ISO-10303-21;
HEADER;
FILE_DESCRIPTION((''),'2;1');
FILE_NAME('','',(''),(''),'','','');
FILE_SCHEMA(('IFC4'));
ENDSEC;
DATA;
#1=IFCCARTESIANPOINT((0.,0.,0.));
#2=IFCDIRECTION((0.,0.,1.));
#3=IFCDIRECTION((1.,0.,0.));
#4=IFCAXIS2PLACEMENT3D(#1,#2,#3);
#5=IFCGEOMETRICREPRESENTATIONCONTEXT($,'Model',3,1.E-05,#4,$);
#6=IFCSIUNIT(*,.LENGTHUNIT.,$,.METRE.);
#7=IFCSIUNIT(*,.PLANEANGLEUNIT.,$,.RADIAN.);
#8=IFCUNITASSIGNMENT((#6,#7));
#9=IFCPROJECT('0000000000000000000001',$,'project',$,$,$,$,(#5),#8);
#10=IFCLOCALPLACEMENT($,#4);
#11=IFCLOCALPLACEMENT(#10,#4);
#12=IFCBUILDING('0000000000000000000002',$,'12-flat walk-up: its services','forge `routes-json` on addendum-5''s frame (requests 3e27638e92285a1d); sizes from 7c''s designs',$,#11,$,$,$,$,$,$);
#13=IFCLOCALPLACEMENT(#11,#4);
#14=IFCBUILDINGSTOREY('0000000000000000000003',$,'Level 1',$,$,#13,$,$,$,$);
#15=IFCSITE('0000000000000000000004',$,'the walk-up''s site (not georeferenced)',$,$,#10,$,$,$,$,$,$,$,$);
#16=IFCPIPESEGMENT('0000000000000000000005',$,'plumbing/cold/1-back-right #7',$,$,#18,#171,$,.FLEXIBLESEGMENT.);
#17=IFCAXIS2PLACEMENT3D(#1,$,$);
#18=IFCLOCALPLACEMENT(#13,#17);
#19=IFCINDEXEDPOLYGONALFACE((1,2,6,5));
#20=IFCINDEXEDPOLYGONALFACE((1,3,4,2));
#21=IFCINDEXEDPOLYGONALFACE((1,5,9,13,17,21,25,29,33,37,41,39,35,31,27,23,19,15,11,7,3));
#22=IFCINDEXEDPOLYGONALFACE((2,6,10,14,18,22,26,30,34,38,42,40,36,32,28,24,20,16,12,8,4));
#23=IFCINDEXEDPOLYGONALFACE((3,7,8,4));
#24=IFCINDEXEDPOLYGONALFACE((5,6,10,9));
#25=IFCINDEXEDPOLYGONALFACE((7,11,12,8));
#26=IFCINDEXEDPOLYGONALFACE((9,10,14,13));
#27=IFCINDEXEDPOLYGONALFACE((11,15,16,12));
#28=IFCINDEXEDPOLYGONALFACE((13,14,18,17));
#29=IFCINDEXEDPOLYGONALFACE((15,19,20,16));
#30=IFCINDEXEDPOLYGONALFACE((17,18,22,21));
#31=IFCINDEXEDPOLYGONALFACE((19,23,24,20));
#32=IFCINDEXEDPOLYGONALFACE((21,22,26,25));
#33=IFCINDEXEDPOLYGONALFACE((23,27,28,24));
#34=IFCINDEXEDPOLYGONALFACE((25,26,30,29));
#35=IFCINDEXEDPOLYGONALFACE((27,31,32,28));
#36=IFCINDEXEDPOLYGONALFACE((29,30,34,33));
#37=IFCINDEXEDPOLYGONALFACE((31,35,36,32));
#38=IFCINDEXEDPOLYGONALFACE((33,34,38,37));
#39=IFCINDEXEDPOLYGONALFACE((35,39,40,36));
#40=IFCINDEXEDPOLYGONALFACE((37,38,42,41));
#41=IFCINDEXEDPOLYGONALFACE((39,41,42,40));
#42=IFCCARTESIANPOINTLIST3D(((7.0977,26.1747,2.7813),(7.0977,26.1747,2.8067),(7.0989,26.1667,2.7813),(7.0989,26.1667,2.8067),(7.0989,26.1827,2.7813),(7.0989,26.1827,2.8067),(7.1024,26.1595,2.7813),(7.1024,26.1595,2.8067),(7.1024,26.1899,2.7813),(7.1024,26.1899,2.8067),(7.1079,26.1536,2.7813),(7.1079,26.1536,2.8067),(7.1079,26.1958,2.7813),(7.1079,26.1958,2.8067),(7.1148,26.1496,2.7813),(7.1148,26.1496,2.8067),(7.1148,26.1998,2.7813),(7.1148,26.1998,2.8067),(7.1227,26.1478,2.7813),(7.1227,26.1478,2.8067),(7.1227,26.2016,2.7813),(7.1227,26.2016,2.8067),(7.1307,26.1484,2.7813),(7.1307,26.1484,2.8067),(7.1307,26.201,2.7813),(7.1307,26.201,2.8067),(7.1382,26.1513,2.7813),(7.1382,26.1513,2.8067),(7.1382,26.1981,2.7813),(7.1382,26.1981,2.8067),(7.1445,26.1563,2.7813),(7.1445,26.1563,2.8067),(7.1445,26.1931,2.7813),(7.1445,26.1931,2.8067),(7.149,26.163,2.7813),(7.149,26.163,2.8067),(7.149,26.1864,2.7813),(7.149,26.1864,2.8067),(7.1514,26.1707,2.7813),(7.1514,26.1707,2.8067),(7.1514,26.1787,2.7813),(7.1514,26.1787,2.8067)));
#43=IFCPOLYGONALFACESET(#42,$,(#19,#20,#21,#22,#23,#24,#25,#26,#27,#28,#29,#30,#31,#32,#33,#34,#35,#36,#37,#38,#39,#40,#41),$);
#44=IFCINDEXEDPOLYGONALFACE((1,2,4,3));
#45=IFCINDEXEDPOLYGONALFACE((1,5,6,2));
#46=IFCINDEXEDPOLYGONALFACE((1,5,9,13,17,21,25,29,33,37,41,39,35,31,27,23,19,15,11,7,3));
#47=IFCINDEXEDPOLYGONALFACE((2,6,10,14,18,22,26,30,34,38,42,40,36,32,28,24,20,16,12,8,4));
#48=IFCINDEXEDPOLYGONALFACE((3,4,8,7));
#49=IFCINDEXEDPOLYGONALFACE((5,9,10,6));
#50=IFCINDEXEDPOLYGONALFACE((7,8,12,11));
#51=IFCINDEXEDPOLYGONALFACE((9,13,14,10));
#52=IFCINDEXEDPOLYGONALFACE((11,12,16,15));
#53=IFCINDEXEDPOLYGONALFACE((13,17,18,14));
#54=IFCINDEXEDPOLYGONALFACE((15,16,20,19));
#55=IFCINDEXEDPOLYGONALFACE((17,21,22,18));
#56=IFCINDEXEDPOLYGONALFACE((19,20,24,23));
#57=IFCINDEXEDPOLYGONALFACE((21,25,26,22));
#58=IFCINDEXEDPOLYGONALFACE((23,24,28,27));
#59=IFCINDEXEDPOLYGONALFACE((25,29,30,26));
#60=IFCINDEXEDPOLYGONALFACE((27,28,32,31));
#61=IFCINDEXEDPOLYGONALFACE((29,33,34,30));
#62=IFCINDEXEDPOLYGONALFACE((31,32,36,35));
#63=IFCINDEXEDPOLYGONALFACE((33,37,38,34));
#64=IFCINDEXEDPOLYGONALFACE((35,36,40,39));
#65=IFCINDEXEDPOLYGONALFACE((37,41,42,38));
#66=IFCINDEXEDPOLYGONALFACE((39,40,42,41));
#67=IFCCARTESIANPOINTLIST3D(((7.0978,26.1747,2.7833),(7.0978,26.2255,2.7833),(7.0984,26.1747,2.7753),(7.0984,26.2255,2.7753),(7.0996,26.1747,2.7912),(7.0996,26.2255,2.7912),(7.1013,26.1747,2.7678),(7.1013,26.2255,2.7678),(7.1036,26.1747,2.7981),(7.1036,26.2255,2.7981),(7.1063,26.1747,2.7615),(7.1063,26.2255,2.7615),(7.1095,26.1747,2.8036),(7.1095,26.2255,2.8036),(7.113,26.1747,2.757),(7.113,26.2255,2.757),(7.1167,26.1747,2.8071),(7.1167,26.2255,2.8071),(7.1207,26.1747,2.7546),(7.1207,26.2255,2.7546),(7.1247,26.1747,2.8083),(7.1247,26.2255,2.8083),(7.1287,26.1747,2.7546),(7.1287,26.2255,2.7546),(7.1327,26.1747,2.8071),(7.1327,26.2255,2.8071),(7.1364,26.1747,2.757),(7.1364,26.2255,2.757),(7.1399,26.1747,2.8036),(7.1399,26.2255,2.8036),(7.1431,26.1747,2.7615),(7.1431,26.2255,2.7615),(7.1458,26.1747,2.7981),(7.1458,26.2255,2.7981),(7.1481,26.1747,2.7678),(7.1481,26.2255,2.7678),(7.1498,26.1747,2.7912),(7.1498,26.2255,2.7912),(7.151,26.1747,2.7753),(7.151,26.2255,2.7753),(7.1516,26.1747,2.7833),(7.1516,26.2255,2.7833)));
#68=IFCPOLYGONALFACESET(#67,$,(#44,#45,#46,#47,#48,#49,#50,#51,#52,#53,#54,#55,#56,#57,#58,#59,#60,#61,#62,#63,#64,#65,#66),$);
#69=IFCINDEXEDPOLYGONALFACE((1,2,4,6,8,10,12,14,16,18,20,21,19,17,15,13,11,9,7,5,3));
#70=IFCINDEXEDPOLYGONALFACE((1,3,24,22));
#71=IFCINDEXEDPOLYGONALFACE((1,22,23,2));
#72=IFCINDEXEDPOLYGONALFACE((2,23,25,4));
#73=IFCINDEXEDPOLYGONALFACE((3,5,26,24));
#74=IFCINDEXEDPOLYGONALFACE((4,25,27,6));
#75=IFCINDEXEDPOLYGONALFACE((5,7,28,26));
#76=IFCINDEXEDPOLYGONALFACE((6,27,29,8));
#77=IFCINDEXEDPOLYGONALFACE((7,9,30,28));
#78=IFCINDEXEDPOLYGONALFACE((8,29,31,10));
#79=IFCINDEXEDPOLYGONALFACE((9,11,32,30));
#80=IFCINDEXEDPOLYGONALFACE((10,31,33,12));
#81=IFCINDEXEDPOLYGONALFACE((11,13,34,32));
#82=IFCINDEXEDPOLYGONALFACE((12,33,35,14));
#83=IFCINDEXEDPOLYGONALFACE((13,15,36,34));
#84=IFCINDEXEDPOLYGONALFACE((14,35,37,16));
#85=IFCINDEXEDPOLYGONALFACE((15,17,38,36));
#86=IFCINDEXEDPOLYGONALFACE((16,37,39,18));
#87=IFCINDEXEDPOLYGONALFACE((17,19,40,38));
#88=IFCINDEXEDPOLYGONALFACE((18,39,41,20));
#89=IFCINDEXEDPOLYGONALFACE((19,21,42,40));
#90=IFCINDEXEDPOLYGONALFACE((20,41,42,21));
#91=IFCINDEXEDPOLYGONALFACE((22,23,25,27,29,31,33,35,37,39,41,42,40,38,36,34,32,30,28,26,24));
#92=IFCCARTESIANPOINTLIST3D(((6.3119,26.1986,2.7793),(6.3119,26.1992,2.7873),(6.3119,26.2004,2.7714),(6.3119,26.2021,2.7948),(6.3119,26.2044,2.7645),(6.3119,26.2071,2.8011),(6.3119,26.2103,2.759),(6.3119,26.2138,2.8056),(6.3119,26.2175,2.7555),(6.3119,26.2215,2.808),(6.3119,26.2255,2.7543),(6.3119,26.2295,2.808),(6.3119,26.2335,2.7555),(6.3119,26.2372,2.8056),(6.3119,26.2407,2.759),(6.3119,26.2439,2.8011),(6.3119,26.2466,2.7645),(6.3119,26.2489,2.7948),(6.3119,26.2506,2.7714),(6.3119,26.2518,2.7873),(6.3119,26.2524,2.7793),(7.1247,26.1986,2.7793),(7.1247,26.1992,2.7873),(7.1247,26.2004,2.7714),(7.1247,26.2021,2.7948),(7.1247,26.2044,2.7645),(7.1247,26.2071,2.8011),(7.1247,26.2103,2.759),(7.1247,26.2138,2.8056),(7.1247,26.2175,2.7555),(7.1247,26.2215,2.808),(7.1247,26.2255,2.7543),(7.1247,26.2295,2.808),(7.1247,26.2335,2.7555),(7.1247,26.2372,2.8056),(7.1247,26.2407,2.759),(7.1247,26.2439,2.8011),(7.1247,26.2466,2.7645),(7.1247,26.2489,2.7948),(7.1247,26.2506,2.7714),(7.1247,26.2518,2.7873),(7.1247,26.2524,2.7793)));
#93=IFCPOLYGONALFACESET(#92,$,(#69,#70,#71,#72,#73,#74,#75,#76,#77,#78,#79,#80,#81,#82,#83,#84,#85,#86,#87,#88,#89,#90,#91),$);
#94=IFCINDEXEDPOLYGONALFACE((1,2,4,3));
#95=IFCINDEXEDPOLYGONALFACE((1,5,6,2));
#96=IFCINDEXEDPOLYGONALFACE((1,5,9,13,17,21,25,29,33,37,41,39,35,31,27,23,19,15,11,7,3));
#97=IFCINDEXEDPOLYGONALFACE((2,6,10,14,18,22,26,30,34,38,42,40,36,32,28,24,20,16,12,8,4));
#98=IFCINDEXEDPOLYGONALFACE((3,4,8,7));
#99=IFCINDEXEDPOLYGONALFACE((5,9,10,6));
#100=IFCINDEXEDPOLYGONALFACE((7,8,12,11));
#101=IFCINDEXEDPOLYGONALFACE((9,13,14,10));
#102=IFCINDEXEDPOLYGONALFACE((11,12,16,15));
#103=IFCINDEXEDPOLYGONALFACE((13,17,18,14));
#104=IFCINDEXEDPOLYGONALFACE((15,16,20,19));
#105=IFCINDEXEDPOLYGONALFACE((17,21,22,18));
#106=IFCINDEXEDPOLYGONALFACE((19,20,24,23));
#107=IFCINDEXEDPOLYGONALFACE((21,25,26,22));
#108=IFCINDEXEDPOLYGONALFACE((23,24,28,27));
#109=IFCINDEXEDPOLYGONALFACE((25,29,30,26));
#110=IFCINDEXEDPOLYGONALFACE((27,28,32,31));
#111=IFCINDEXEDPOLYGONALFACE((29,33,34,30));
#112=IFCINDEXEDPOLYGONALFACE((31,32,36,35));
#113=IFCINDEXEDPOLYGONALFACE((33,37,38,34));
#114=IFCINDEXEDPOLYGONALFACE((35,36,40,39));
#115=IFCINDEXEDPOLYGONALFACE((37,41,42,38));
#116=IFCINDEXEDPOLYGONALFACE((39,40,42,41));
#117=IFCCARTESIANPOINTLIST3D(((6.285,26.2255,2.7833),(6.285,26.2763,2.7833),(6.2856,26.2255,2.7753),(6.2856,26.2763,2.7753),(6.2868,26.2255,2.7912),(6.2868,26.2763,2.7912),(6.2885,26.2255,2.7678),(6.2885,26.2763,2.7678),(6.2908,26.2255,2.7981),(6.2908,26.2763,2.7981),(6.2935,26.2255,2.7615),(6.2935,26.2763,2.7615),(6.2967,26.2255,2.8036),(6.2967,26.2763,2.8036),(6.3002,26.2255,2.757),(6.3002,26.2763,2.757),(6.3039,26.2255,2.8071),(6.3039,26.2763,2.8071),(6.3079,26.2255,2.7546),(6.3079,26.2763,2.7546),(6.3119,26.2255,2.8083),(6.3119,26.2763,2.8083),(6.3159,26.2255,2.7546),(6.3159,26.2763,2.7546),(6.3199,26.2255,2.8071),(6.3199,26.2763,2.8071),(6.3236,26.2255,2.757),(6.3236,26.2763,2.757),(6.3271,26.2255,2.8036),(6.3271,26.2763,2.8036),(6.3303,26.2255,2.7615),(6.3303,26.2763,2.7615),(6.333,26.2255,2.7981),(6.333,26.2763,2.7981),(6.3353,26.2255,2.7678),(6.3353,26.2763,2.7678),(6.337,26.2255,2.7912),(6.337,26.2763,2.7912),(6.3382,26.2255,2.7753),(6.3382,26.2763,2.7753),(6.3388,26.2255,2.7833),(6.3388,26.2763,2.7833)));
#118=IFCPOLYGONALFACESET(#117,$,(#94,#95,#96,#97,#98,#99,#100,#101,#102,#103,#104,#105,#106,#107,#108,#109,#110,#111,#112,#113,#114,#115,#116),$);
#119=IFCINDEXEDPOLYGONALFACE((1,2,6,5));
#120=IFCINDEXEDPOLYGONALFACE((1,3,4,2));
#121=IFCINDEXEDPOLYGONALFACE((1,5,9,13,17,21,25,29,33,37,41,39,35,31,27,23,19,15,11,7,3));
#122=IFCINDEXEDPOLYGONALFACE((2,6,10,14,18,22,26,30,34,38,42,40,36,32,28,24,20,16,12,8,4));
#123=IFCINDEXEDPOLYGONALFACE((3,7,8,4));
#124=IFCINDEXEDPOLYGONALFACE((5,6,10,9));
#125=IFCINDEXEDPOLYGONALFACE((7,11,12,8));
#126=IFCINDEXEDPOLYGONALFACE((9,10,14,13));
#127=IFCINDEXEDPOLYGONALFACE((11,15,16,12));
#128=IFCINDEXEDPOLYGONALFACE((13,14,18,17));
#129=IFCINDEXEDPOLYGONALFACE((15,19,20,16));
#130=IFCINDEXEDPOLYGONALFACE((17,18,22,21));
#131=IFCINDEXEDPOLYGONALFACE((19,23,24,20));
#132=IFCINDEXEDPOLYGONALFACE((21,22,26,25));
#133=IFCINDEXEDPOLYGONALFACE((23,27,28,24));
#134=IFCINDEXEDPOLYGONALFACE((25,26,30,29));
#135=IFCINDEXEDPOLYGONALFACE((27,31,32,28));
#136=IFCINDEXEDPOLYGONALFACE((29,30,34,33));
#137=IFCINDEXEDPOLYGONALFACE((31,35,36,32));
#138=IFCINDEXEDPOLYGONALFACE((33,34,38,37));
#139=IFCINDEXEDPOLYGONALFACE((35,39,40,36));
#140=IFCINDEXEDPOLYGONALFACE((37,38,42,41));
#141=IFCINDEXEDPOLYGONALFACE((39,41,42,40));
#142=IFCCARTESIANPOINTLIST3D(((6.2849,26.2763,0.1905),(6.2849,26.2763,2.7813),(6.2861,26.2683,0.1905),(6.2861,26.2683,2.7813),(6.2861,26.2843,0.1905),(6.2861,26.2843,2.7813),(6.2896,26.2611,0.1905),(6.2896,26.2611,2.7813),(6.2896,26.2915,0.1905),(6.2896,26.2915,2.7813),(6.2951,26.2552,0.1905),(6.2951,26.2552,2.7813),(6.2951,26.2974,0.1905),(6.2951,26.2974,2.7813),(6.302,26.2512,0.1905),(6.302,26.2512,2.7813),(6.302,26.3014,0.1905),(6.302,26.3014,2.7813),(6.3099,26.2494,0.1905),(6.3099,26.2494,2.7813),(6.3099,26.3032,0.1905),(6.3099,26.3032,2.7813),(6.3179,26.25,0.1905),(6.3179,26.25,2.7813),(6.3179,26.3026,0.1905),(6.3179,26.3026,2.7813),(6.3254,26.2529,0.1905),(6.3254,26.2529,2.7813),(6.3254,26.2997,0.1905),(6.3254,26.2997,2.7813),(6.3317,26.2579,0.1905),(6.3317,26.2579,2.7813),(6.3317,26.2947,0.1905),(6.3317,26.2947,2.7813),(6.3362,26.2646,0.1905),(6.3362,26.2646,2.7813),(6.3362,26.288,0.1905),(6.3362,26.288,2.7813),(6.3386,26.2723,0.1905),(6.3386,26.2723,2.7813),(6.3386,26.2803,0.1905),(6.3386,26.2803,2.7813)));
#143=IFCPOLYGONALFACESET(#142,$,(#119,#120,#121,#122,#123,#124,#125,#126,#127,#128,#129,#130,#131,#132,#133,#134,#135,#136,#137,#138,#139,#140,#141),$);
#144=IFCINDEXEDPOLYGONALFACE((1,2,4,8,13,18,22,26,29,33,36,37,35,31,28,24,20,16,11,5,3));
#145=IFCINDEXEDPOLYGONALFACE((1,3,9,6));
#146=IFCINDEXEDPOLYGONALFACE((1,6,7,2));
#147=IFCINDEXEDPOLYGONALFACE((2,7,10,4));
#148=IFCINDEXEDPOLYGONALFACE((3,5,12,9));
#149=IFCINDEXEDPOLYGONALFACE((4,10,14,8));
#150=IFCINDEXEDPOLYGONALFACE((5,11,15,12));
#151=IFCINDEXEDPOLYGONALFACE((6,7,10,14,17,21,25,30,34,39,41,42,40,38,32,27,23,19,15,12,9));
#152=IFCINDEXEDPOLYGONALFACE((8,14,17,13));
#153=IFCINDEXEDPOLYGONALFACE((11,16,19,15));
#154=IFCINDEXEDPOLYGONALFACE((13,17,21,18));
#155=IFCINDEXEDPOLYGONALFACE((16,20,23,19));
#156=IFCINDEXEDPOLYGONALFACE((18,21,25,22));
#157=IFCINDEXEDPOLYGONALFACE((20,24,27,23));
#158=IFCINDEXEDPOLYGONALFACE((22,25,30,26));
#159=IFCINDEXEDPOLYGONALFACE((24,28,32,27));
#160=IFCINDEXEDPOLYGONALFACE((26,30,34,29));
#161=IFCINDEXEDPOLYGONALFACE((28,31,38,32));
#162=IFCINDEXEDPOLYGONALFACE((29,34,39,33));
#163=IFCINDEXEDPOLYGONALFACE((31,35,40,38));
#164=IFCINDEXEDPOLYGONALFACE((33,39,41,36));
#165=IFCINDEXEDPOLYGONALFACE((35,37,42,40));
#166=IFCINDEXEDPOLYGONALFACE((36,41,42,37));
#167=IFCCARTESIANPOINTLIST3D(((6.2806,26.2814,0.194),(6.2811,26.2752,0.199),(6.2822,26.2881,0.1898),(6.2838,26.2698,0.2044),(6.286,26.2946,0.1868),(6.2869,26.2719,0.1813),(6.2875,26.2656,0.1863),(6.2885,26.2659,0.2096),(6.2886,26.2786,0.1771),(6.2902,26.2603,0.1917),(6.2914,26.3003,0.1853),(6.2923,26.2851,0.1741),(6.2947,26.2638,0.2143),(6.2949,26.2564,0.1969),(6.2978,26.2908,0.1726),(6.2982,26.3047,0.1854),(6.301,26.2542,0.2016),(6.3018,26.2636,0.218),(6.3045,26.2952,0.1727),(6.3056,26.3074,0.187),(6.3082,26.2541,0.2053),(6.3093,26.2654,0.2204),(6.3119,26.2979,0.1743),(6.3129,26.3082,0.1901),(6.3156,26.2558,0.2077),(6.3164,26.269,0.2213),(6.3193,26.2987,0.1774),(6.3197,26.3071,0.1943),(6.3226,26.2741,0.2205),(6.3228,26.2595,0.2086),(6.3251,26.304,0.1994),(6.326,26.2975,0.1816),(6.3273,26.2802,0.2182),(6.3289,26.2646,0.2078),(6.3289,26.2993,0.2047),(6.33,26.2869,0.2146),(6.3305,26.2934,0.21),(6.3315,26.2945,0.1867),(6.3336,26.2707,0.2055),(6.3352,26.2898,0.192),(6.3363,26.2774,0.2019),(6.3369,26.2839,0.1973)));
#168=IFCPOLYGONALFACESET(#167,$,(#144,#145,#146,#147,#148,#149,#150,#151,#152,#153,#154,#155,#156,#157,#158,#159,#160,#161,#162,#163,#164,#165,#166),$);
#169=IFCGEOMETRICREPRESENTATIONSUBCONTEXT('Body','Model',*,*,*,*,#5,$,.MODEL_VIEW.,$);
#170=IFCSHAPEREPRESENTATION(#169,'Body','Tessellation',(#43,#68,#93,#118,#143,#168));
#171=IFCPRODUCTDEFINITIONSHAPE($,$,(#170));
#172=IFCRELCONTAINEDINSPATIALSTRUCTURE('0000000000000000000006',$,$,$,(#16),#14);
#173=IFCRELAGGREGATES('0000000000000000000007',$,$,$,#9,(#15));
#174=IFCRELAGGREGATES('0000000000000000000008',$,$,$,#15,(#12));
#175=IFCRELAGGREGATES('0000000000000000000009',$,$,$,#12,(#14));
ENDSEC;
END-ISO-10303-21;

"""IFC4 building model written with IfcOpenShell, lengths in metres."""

from ifc_helpers import new_model, entity, si_unit, frame, origin_with_axes, place, context, subcontext, project, spatial, element, save


model = new_model("IFC4")

# Units and contexts
model_context = context("Model", 3, precision=1e-05, world=origin_with_axes())
body_context = subcontext(model_context, "Body", "Model", "MODEL_VIEW")
ifc_project = project(units=[si_unit("LENGTHUNIT", "METRE"), si_unit("PLANEANGLEUNIT", "RADIAN")], contexts=[model_context])

# Site, building, storey
site_placement = place(None, origin_with_axes())
site = spatial("IfcSite", under=ifc_project, at=site_placement, Name="the walk-up's site (not georeferenced)")
building_placement = place(site_placement, origin_with_axes())
building = spatial("IfcBuilding", under=site, at=building_placement, Name="12-flat walk-up: its services", Description="forge `routes-json` on addendum-5's frame (requests 3e27638e92285a1d); sizes from 7c's designs")
storey_placement = place(building_placement, origin_with_axes())
storey = spatial("IfcBuildingStorey", under=building, at=storey_placement, Name="Level 1")

# Pipe segment
pipe_segment_1_placement = place(storey_placement, frame((7.1247, 26.1747, 2.8067), z_axis=(0.0, 0.0, 1.0), x_axis=(1.0, 0.0, 0.0)))
element("IfcPipeSegment", 1, at=pipe_segment_1_placement, inside=storey, Name="plumbing/cold/1-back-right #7", PredefinedType="FLEXIBLESEGMENT", context=body_context, shape_type="AdvancedSweptSolid", body=[
    entity("IfcSweptDiskSolid", entity("IfcPolyline", [entity("IfcCartesianPoint", [0.0, 0.0, 0.0]), entity("IfcCartesianPoint", [0.0, 0.0, -0.0254])]), 0.027),
    entity("IfcSweptDiskSolid", entity("IfcPolyline", [entity("IfcCartesianPoint", [0.0, 0.0, -0.0254]), entity("IfcCartesianPoint", [0.0, 0.0508, -0.0254])]), 0.027),
    entity("IfcSweptDiskSolid", entity("IfcPolyline", [entity("IfcCartesianPoint", [0.0, 0.0508, -0.0254]), entity("IfcCartesianPoint", [-0.8128, 0.0508, -0.0254])]), 0.027),
    entity("IfcSweptDiskSolid", entity("IfcPolyline", [entity("IfcCartesianPoint", [-0.8128, 0.0508, -0.0254]), entity("IfcCartesianPoint", [-0.8128, 0.1016, -0.0254])]), 0.027),
    entity("IfcSweptDiskSolid", entity("IfcPolyline", [entity("IfcCartesianPoint", [-0.8128, 0.1016, -0.0254]), entity("IfcCartesianPoint", [-0.8128, 0.1016, -2.6162])]), 0.027),
    entity("IfcSweptDiskSolid", entity("IfcPolyline", [entity("IfcCartesianPoint", [-0.8128, 0.1016, -2.6162]), entity("IfcCartesianPoint", [-0.8191, 0.1111, -2.6035])]), 0.027),
])

save(model, "model.ifc")
